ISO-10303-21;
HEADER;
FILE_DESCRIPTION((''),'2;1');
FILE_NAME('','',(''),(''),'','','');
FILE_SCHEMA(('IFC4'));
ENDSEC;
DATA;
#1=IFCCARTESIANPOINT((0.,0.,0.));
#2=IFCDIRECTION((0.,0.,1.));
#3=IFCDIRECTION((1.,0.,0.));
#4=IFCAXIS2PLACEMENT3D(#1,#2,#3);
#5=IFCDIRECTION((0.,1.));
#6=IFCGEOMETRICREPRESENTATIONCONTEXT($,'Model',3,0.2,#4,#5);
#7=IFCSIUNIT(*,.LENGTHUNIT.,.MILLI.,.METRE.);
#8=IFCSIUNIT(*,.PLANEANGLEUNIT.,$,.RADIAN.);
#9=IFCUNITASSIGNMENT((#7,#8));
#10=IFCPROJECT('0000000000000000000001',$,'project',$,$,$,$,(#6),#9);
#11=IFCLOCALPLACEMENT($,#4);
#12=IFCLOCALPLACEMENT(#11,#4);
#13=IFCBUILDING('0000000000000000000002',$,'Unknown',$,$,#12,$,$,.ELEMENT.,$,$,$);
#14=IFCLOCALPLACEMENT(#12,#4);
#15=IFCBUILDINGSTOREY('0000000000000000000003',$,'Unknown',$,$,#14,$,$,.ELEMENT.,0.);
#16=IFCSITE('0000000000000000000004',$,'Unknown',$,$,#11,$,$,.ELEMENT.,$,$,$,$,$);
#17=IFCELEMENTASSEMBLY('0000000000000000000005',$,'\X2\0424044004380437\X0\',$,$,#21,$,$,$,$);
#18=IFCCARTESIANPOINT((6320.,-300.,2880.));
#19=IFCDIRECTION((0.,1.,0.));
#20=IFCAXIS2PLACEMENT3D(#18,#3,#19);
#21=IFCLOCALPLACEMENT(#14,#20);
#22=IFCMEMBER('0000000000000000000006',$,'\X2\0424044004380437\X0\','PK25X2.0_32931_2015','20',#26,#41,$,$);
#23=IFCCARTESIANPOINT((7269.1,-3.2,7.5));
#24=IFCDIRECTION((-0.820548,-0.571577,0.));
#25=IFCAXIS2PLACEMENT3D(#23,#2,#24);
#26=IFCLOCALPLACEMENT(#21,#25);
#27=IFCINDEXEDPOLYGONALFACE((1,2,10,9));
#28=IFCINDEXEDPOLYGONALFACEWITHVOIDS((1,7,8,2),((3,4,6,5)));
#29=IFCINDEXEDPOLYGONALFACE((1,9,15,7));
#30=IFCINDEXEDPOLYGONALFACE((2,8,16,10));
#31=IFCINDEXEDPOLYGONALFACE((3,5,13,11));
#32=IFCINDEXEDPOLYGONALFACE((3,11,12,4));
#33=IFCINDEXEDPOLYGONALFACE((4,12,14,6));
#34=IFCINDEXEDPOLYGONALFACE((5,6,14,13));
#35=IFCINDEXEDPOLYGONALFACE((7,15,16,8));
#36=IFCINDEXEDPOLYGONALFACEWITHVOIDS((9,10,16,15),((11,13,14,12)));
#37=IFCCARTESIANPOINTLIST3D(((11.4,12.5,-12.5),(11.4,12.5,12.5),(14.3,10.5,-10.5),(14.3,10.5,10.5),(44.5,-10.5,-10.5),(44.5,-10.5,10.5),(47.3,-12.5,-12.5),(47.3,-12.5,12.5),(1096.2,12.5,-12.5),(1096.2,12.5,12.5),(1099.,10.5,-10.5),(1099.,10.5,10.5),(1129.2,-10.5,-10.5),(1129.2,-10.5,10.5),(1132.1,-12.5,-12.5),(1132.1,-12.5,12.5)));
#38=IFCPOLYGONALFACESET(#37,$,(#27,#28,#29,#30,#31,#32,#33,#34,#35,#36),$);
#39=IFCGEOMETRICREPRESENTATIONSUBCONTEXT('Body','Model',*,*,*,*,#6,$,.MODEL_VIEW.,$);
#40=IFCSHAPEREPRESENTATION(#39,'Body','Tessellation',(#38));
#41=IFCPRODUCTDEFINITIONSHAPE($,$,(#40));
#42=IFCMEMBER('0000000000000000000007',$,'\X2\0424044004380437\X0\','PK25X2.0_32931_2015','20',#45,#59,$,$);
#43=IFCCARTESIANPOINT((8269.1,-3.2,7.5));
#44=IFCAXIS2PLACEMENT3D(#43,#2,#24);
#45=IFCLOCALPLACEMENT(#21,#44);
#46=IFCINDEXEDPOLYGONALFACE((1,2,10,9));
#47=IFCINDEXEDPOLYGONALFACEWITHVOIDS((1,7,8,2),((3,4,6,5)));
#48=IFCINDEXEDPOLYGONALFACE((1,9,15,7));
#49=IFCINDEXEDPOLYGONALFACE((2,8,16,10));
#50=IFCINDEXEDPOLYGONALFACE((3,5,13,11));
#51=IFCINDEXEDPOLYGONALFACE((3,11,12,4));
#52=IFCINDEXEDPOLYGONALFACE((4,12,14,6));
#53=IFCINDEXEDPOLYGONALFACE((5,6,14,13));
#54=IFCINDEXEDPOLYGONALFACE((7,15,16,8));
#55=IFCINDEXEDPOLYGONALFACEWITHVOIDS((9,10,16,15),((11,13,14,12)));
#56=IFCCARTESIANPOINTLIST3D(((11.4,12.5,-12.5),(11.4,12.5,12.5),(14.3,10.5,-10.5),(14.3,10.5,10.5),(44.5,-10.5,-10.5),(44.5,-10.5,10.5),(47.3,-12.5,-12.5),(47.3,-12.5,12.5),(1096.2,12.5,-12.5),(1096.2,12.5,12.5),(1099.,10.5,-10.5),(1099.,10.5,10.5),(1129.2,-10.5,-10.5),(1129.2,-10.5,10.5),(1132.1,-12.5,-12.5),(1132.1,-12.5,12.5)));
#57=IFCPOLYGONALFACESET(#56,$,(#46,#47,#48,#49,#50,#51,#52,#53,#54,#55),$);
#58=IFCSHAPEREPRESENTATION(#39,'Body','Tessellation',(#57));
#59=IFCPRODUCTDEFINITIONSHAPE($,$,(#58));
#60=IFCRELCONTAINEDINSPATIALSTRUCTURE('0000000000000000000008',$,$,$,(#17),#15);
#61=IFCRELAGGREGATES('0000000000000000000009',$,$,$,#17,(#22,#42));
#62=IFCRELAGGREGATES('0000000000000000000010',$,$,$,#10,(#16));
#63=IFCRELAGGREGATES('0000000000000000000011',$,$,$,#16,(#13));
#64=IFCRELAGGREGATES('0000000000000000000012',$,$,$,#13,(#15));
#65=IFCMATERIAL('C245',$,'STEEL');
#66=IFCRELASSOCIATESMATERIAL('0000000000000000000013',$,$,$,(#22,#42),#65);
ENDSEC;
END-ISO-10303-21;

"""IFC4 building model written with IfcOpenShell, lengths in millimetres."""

from ifc_helpers import new_model, si_unit, direction, frame, origin_with_axes, place, context, subcontext, project, spatial, line, indexed_curve, outline, extrude, material, element, aggregate, save


model = new_model("IFC4")

# Units and contexts
model_context = context("Model", 3, precision=0.2, world=origin_with_axes(), true_north=direction((0.0, 1.0)))
body_context = subcontext(model_context, "Body", "Model", "MODEL_VIEW")
ifc_project = project(units=[si_unit("LENGTHUNIT", "METRE", prefix="MILLI"), si_unit("PLANEANGLEUNIT", "RADIAN")], contexts=[model_context])

# Site, building, storey
site_placement = place(None, origin_with_axes())
site = spatial("IfcSite", under=ifc_project, at=site_placement, Name="Unknown", CompositionType="ELEMENT")
building_placement = place(site_placement, origin_with_axes())
building = spatial("IfcBuilding", under=site, at=building_placement, Name="Unknown", CompositionType="ELEMENT")
storey_placement = place(building_placement, origin_with_axes())
storey = spatial("IfcBuildingStorey", under=building, at=storey_placement, Name="Unknown", CompositionType="ELEMENT", Elevation=0.0)

# Shared definitions
ifc_material_1 = material(Name="C245", Category="STEEL")

# Element assembly, members, voiding features
assembly_1_placement = place(storey_placement, frame((6320.0, -300.0, 2880.0), z_axis=(1.0, 0.0, 0.0), x_axis=(0.0, 1.0, 0.0)))
assembly_1 = element("IfcElementAssembly", 1, at=assembly_1_placement, inside=storey, Name="Фриз")
member_1_placement = place(assembly_1_placement, frame((7269.1, -3.2, 7.5), z_axis=(0.0, 0.0, 1.0), x_axis=(-0.820548, -0.571577, 0.0)))
member_1 = element("IfcMember", 2, at=member_1_placement, material=ifc_material_1, Name="Фриз", Description="PK25X2.0_32931_2015", ObjectType="20", context=body_context, shape_type="SolidModel", body=[
    extrude(outline(indexed_curve([(-12.5, -12.5), (12.5, -12.5), (12.5, 12.5), (-12.5, 12.5)], segments=[line(1, 2, 3, 4, 1)]), holes=[indexed_curve([(-10.5, -10.5), (-10.5, 10.5), (10.5, 10.5), (10.5, -10.5)], segments=[line(1, 2, 3, 4, 1)])]), frame((0.0, 0.0, 0.0), z_axis=(-1.0, 0.0, 0.0), x_axis=(0.0, 0.0, 1.0)), (0.0, 0.0, -1.0), 1143.5),
])
voiding_feature_1_placement = place(member_1_placement, frame((899.1, -630.2, -7.5), z_axis=(0.0, 0.0, 1.0), x_axis=(-0.820548, 0.571577, 0.0)))
element("IfcVoidingFeature", 3, at=voiding_feature_1_placement, cuts=member_1, Name="CUT_BEAM", ObjectType="(?)", PredefinedType="HOLE", context=body_context, shape_type="SolidModel", body=[
    extrude(outline(indexed_curve([(-20.0, -20.0), (20.0, -20.0), (20.0, 20.0), (-20.0, 20.0)], segments=[line(1, 2, 3, 4, 1)])), frame((0.0, 0.0, 0.0), z_axis=(-1.0, 0.0, 0.0), x_axis=(0.0, 0.0, 1.0)), (0.0, 0.0, -1.0), 2205.1),
])
voiding_feature_2_placement = place(member_1_placement, frame((2053.8, -630.2, -7.5), z_axis=(0.0, 0.0, 1.0), x_axis=(-0.820548, 0.571577, 0.0)))
element("IfcVoidingFeature", 4, at=voiding_feature_2_placement, cuts=member_1, Name="CUT_BEAM", ObjectType="(?)", PredefinedType="HOLE", context=body_context, shape_type="SolidModel", body=[
    extrude(outline(indexed_curve([(-20.0, -20.0), (20.0, -20.0), (20.0, 20.0), (-20.0, 20.0)], segments=[line(1, 2, 3, 4, 1)])), frame((0.0, 0.0, 0.0), z_axis=(-1.0, 0.0, 0.0), x_axis=(0.0, 0.0, 1.0)), (0.0, 0.0, -1.0), 2205.1),
])
member_2_placement = place(assembly_1_placement, frame((8269.1, -3.2, 7.5), z_axis=(0.0, 0.0, 1.0), x_axis=(-0.820548, -0.571577, 0.0)))
member_2 = element("IfcMember", 5, at=member_2_placement, material=ifc_material_1, Name="Фриз", Description="PK25X2.0_32931_2015", ObjectType="20", context=body_context, shape_type="SolidModel", body=[
    extrude(outline(indexed_curve([(-12.5, -12.5), (12.5, -12.5), (12.5, 12.5), (-12.5, 12.5)], segments=[line(1, 2, 3, 4, 1)]), holes=[indexed_curve([(-10.5, -10.5), (-10.5, 10.5), (10.5, 10.5), (10.5, -10.5)], segments=[line(1, 2, 3, 4, 1)])]), frame((0.0, 0.0, 0.0), z_axis=(-1.0, 0.0, 0.0), x_axis=(0.0, 0.0, 1.0)), (0.0, 0.0, -1.0), 1143.5),
])
voiding_feature_3_placement = place(member_2_placement, frame((899.1, -630.2, -7.5), z_axis=(0.0, 0.0, 1.0), x_axis=(-0.820548, 0.571577, 0.0)))
element("IfcVoidingFeature", 6, at=voiding_feature_3_placement, cuts=member_2, Name="CUT_BEAM", ObjectType="(?)", PredefinedType="HOLE", context=body_context, shape_type="SolidModel", body=[
    extrude(outline(indexed_curve([(-20.0, -20.0), (20.0, -20.0), (20.0, 20.0), (-20.0, 20.0)], segments=[line(1, 2, 3, 4, 1)])), frame((0.0, 0.0, 0.0), z_axis=(-1.0, 0.0, 0.0), x_axis=(0.0, 0.0, 1.0)), (0.0, 0.0, -1.0), 2205.1),
])
voiding_feature_4_placement = place(member_2_placement, frame((2053.8, -630.2, -7.5), z_axis=(0.0, 0.0, 1.0), x_axis=(-0.820548, 0.571577, 0.0)))
element("IfcVoidingFeature", 7, at=voiding_feature_4_placement, cuts=member_2, Name="CUT_BEAM", ObjectType="(?)", PredefinedType="HOLE", context=body_context, shape_type="SolidModel", body=[
    extrude(outline(indexed_curve([(-20.0, -20.0), (20.0, -20.0), (20.0, 20.0), (-20.0, 20.0)], segments=[line(1, 2, 3, 4, 1)])), frame((0.0, 0.0, 0.0), z_axis=(-1.0, 0.0, 0.0), x_axis=(0.0, 0.0, 1.0)), (0.0, 0.0, -1.0), 2205.1),
])
aggregate(assembly_1, [member_1, member_2])

save(model, "model.ifc")
